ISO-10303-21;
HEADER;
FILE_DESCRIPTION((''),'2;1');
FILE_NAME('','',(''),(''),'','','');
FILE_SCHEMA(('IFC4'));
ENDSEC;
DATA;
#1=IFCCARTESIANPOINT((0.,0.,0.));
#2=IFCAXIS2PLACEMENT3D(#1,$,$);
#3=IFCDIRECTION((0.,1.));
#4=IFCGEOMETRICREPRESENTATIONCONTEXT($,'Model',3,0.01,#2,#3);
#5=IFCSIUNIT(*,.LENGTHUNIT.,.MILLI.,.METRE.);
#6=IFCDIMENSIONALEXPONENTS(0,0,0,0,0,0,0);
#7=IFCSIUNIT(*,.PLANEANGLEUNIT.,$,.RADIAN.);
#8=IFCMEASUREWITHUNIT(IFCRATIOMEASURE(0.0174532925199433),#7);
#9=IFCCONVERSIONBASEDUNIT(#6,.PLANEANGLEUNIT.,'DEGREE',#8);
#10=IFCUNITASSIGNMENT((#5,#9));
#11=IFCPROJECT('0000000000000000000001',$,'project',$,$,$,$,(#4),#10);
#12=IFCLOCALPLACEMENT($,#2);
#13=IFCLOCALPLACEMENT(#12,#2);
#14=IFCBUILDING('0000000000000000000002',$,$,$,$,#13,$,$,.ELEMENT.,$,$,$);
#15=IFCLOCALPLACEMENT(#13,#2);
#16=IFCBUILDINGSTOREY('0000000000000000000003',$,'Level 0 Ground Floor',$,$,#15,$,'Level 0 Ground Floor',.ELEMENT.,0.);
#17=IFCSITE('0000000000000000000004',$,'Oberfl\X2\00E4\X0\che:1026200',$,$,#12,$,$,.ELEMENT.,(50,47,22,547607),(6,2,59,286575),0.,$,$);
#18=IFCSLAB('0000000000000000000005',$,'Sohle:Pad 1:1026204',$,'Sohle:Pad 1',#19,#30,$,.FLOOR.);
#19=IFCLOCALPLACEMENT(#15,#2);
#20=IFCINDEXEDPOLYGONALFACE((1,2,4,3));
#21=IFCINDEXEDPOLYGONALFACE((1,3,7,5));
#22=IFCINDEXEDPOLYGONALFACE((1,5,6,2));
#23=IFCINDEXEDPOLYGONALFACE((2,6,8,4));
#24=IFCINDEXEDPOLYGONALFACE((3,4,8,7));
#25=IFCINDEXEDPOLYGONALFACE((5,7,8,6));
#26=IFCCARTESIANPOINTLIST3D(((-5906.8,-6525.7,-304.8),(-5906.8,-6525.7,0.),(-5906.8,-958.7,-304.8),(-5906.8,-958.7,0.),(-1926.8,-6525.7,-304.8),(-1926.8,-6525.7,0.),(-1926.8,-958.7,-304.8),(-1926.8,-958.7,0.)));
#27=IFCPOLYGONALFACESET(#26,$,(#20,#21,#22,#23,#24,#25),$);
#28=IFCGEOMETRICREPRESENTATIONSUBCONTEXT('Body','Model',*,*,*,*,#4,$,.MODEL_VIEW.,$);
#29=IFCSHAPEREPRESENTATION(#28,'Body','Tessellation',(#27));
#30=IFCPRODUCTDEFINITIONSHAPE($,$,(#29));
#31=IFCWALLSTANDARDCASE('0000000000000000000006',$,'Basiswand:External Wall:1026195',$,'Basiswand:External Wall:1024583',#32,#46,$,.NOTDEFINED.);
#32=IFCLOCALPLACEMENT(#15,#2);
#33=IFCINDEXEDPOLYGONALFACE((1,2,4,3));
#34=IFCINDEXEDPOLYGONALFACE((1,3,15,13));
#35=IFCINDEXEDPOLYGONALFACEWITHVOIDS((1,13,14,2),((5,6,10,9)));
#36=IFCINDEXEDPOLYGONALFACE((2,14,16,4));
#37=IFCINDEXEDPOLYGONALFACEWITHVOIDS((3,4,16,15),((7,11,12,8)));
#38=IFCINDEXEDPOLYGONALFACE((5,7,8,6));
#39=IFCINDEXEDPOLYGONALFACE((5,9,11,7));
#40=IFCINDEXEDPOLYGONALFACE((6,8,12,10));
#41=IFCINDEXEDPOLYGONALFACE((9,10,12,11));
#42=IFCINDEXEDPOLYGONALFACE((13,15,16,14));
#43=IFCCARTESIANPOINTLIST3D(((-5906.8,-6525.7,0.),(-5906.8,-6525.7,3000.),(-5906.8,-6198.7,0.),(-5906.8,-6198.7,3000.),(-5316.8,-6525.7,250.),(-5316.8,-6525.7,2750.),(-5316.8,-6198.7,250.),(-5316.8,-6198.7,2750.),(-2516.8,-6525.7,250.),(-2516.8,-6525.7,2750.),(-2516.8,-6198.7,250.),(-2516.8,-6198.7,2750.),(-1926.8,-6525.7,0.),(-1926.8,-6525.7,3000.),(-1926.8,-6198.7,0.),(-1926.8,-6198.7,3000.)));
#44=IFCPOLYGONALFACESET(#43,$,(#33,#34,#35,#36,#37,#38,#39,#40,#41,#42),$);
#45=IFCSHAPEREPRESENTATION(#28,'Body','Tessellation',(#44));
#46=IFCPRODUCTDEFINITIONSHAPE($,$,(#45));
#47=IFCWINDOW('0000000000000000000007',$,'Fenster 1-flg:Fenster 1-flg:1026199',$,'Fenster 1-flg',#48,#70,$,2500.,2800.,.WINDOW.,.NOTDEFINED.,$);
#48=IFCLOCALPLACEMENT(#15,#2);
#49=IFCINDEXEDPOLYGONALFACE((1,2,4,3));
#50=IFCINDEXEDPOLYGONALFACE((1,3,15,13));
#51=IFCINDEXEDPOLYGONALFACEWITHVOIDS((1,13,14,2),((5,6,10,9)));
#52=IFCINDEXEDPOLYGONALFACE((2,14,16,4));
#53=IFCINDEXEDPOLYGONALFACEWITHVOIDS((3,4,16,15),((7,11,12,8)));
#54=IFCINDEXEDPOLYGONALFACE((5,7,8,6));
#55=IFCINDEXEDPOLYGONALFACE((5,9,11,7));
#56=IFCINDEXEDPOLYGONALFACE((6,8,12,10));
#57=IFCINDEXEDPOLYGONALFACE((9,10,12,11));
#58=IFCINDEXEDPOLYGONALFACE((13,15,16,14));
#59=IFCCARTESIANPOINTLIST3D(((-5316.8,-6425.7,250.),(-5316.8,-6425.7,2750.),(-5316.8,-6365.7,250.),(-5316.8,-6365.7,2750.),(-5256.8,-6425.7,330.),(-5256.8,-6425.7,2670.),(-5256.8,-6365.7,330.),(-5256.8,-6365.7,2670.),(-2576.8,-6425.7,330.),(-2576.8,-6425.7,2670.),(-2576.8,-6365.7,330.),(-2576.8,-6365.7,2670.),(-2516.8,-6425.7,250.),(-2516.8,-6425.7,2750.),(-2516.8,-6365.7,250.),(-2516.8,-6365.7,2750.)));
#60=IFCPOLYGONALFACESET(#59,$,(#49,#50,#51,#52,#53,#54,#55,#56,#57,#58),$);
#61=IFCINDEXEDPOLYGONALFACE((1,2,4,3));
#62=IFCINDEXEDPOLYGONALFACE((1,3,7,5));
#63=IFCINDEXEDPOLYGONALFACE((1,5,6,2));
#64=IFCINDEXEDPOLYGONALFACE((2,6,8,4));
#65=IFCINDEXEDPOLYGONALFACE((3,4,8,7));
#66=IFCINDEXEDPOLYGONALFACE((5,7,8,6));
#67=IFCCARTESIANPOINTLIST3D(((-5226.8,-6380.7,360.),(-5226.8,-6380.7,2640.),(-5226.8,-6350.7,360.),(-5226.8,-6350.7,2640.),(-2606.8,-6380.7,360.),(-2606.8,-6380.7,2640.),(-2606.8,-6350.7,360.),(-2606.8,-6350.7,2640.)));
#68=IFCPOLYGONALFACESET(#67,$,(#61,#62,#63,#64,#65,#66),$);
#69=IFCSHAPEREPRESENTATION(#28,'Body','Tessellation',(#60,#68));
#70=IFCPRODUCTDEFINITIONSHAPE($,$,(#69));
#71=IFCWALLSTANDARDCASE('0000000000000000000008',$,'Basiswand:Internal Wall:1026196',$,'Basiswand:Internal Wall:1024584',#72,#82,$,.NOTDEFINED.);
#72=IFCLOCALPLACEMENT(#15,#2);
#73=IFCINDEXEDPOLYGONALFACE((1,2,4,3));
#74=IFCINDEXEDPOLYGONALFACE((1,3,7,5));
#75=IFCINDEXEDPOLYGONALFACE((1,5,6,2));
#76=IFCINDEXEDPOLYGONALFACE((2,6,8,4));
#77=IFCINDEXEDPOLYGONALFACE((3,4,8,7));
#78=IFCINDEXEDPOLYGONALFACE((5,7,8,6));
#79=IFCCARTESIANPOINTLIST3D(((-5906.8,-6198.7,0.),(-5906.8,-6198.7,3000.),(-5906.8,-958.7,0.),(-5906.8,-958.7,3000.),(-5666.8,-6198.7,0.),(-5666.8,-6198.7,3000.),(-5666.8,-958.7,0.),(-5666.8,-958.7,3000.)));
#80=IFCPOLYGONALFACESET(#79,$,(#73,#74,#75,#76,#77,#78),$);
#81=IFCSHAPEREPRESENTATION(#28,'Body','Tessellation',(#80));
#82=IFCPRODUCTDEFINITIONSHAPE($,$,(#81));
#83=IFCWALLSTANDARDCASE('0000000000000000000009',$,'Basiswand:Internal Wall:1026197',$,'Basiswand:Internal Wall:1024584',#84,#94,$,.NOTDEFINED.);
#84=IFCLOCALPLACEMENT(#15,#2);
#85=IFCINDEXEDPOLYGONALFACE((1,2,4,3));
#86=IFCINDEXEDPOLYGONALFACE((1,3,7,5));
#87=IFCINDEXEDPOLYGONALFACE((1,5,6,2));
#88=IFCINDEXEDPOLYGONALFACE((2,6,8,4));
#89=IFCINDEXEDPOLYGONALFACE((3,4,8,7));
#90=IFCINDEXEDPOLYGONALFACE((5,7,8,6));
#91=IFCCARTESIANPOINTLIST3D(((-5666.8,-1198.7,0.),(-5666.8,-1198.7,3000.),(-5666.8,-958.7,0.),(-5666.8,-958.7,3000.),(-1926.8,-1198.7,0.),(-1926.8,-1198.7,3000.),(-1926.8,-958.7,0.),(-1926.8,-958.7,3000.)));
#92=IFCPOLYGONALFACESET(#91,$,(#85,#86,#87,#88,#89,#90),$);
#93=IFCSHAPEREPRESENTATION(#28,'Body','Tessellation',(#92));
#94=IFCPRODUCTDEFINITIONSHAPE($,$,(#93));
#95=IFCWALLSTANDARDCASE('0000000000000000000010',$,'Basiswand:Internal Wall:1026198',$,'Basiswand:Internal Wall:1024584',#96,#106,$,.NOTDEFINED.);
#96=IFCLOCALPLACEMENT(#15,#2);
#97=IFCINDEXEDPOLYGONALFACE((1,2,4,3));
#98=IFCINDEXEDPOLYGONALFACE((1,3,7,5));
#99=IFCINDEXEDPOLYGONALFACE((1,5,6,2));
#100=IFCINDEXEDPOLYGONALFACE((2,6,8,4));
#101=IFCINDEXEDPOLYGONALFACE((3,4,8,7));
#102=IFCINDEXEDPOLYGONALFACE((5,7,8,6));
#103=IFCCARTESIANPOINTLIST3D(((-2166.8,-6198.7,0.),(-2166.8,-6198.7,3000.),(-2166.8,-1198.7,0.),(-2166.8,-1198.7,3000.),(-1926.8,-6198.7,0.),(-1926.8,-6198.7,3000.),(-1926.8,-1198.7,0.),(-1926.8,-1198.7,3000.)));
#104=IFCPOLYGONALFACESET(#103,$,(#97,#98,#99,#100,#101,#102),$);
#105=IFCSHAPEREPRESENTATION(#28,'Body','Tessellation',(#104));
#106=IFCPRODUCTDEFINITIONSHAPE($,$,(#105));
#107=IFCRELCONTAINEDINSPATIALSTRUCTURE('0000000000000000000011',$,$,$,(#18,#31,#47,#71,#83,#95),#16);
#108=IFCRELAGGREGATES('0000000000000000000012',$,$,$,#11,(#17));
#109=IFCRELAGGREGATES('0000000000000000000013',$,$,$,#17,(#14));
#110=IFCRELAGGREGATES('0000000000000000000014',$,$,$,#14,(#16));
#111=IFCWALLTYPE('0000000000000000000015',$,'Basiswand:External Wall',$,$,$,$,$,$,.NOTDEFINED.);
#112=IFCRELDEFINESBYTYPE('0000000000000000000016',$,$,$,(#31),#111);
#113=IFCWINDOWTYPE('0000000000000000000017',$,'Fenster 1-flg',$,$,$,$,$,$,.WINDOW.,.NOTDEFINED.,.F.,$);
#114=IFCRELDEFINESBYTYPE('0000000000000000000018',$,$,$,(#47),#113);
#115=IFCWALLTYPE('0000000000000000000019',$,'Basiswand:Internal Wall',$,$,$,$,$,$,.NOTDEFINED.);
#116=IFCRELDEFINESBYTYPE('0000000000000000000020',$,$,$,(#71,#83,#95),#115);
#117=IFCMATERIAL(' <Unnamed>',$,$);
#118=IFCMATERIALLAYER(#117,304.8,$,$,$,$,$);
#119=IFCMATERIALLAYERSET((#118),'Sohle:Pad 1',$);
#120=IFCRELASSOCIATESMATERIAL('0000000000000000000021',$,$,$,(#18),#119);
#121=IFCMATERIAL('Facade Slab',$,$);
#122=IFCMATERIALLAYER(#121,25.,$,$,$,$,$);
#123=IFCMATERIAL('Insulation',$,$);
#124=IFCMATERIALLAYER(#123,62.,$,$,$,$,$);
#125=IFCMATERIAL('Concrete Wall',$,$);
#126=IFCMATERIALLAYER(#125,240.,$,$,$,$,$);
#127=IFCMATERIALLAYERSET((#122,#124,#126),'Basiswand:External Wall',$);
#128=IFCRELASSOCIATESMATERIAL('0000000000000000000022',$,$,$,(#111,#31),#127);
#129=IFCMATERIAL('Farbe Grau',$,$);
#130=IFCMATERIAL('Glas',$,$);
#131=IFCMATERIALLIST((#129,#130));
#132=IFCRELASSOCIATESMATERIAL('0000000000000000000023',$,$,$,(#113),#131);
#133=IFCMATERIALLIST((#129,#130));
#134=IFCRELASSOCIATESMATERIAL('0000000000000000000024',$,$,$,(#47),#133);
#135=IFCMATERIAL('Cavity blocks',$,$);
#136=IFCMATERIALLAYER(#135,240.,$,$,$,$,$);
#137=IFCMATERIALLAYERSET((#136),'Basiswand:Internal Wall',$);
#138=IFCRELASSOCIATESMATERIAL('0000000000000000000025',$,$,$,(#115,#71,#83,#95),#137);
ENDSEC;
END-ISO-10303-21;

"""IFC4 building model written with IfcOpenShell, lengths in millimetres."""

from ifc_helpers import new_model, entity, si_unit, converted_unit, direction, frame, frame_2d, origin, origin_2d_with_axis, place, context, subcontext, project, spatial, polyline, rectangle, outline, extrude, clip, bounded_halfspace, source, transform, mapped, material, material_list, layer, layer_set, layer_usage, type_object, type_shapes, element, fill, save


model = new_model("IFC4")

# Units and contexts
model_context = context("Model", 3, precision=0.01, world=origin(), true_north=direction((0.0, 1.0)))
body_context = subcontext(model_context, "Body", "Model", "MODEL_VIEW")
ifc_project = project(units=[si_unit("LENGTHUNIT", "METRE", prefix="MILLI"), converted_unit("PLANEANGLEUNIT", "DEGREE", entity("IfcRatioMeasure", 0.0174532925199433), si_unit("PLANEANGLEUNIT", "RADIAN"), dimensions=[0, 0, 0, 0, 0, 0, 0])], contexts=[model_context])

# Site, building, storey
site_placement = place(None, origin())
site = spatial("IfcSite", under=ifc_project, at=site_placement, Name="Oberfläche:1026200", CompositionType="ELEMENT", RefLatitude=(50, 47, 22, 547607), RefLongitude=(6, 2, 59, 286575), RefElevation=0.0)
building_placement = place(site_placement, origin())
building = spatial("IfcBuilding", under=site, at=building_placement, CompositionType="ELEMENT")
storey_placement = place(building_placement, origin())
storey = spatial("IfcBuildingStorey", under=building, at=storey_placement, Name="Level 0 Ground Floor", LongName="Level 0 Ground Floor", CompositionType="ELEMENT", Elevation=0.0)

# Slab
ifc_material_1 = material(Name=" <Unnamed>")
ifc_layer_1 = layer(ifc_material_1, 304.8)
ifc_layer_set_1 = layer_set([ifc_layer_1], Name="Sohle:Pad 1")
ifc_layer_usage_1 = layer_usage(ifc_layer_set_1, "AXIS3", "NEGATIVE", 0.0)
slab_placement = place(storey_placement, origin())
element("IfcSlab", 1, at=slab_placement, inside=storey, material=ifc_layer_usage_1, Name="Sohle:Pad 1:1026204", ObjectType="Sohle:Pad 1", PredefinedType="FLOOR", context=body_context, shape_type="SweptSolid", body=[
    extrude(rectangle(XDim=3980.0, YDim=5567.0, at=frame_2d((0.0, 0.0), x_axis=(1.0, 0.0))), frame((-3916.8, -3742.2, -304.8), z_axis=(0.0, 0.0, 1.0), x_axis=(-1.0, 0.0, 0.0)), (0.0, 0.0, 1.0), 304.8),
])

# Wall, opening, window
ifc_material_2 = material(Name="Facade Slab")
ifc_layer_2 = layer(ifc_material_2, 25.0)
ifc_material_3 = material(Name="Insulation")
ifc_layer_3 = layer(ifc_material_3, 62.0)
ifc_material_4 = material(Name="Concrete Wall")
ifc_layer_4 = layer(ifc_material_4, 240.0)
ifc_layer_set_2 = layer_set([ifc_layer_2, ifc_layer_3, ifc_layer_4], Name="Basiswand:External Wall")
ifc_layer_usage_2 = layer_usage(ifc_layer_set_2, "AXIS2", "POSITIVE", -163.5)
wall_type_1 = type_object("IfcWallType", Name="Basiswand:External Wall", PredefinedType="NOTDEFINED", material=ifc_layer_set_2)
wall_1_placement = place(storey_placement, frame((-5906.8, -6362.2, 0.0)))
wall_1 = element("IfcWallStandardCase", 2, at=wall_1_placement, inside=storey, type_object=wall_type_1, material=ifc_layer_usage_2, Name="Basiswand:External Wall:1026195", ObjectType="Basiswand:External Wall:1024583", PredefinedType="NOTDEFINED", context=body_context, shape_type="Clipping", body=[
    clip(extrude(rectangle(XDim=3980.0, YDim=327.0, at=frame_2d((1990.0, 0.0), x_axis=(-1.0, 0.0))), origin(), (0.0, 0.0, 1.0), 3000.0), bounded_halfspace(frame((0.0, -163.5, 3000.0), z_axis=(0.0, 0.0, -1.0), x_axis=(0.0, -1.0, 0.0)), True, frame((0.0, -163.5, 3000.0)), polyline([(0.0, 0.0), (3980.0, 0.0), (3980.0, 327.0), (3740.0, 327.0), (240.0, 327.0), (0.0, 327.0), (0.0, 0.0)]))),
])
opening_placement = place(wall_1_placement, frame((590.0, -163.5, 250.0)))
opening = element("IfcOpeningElement", 3, at=opening_placement, cuts=wall_1, ObjectType="Opening", PredefinedType="OPENING", context=body_context, shape_type="SweptSolid", body=[
    extrude(rectangle(XDim=2500.0, YDim=2800.0, at=frame_2d((1250.0, 1400.0), x_axis=(1.0, 0.0))), frame((0.0, 0.0, 0.0), z_axis=(0.0, 1.0, 0.0), x_axis=(0.0, 0.0, 1.0)), (0.0, 0.0, 1.0), 327.0),
])
ifc_material_5 = material(Name="Farbe Grau")
ifc_material_6 = material(Name="Glas")
ifc_material_list_1 = material_list([ifc_material_5, ifc_material_6])
ifc_material_list_2 = material_list([ifc_material_5, ifc_material_6])
window_type = type_object("IfcWindowType", Name="Fenster 1-flg", ParameterTakesPrecedence=False, PartitioningType="NOTDEFINED", PredefinedType="WINDOW", material=ifc_material_list_2)
shared_shape_1 = source(origin(), body_context, "Body", "SweptSolid", [
    extrude(outline(polyline([(-1250.0, -1400.0), (1250.0, -1400.0), (1250.0, 1400.0), (-1250.0, 1400.0), (-1250.0, -1400.0)]), holes=[polyline([(-1170.0, -1340.0), (-1170.0, 1340.0), (1170.0, 1340.0), (1170.0, -1340.0), (-1170.0, -1340.0)])]), frame((1400.0, 167.0, 1250.0), z_axis=(0.0, 1.0, 0.0), x_axis=(0.0, 0.0, -1.0)), (0.0, 0.0, 1.0), 60.0),
    extrude(rectangle(XDim=30.0, YDim=2620.0, at=origin_2d_with_axis()), frame((1400.0, 167.0, 110.0), z_axis=(0.0, 0.0, 1.0), x_axis=(0.0, 1.0, 0.0)), (0.0, 0.0, 1.0), 2280.0),
])
type_shapes(window_type, [shared_shape_1])
window_placement = place(opening_placement, frame((2800.0, 327.0, 0.0), z_axis=(0.0, 0.0, 1.0), x_axis=(-1.0, 0.0, 0.0)))
window = element("IfcWindow", 4, at=window_placement, inside=storey, type_object=window_type, material=ifc_material_list_1, Name="Fenster 1-flg:Fenster 1-flg:1026199", ObjectType="Fenster 1-flg", OverallHeight=2500.0, OverallWidth=2800.0, PartitioningType="NOTDEFINED", PredefinedType="WINDOW", context=body_context, shape_type="MappedRepresentation", body=[
    mapped(shared_shape_1, transform((0.0, 0.0, 0.0), scale=1.0)),
])
fill(opening, window)

# Walls
ifc_material_7 = material(Name="Cavity blocks")
ifc_layer_5 = layer(ifc_material_7, 240.0)
ifc_layer_set_3 = layer_set([ifc_layer_5], Name="Basiswand:Internal Wall")
ifc_layer_usage_3 = layer_usage(ifc_layer_set_3, "AXIS2", "NEGATIVE", 120.0)
wall_type_2 = type_object("IfcWallType", Name="Basiswand:Internal Wall", PredefinedType="NOTDEFINED", material=ifc_layer_set_3)
wall_2_placement = place(storey_placement, frame((-5786.8, -6198.7, 0.0), z_axis=(0.0, 0.0, 1.0), x_axis=(0.0, 1.0, 0.0)))
element("IfcWallStandardCase", 5, at=wall_2_placement, inside=storey, type_object=wall_type_2, material=ifc_layer_usage_3, Name="Basiswand:Internal Wall:1026196", ObjectType="Basiswand:Internal Wall:1024584", PredefinedType="NOTDEFINED", context=body_context, shape_type="Clipping", body=[
    clip(extrude(rectangle(XDim=5240.0, YDim=240.0, at=frame_2d((2620.0, 0.0), x_axis=(-1.0, 0.0))), origin(), (0.0, 0.0, 1.0), 3000.0), bounded_halfspace(frame((0.0, -120.0, 3000.0), z_axis=(0.0, 0.0, -1.0), x_axis=(-1.0, 0.0, 0.0)), True, frame((0.0, -120.0, 3000.0)), polyline([(0.0, 0.0), (5000.0, 0.0), (5240.0, 0.0), (5240.0, 240.0), (0.0, 240.0), (0.0, 0.0)]))),
])
ifc_layer_usage_4 = layer_usage(ifc_layer_set_3, "AXIS2", "NEGATIVE", 120.0)
wall_3_placement = place(storey_placement, frame((-5666.8, -1078.7, 0.0)))
element("IfcWallStandardCase", 6, at=wall_3_placement, inside=storey, type_object=wall_type_2, material=ifc_layer_usage_4, Name="Basiswand:Internal Wall:1026197", ObjectType="Basiswand:Internal Wall:1024584", PredefinedType="NOTDEFINED", context=body_context, shape_type="Clipping", body=[
    clip(extrude(rectangle(XDim=3740.0, YDim=240.0, at=frame_2d((1870.0, 0.0), x_axis=(-1.0, 0.0))), origin(), (0.0, 0.0, 1.0), 3000.0), bounded_halfspace(frame((0.0, -120.0, 3000.0), z_axis=(0.0, 0.0, -1.0), x_axis=(0.0, -1.0, 0.0)), True, frame((0.0, -120.0, 3000.0)), polyline([(0.0, 0.0), (3500.0, 0.0), (3740.0, 0.0), (3740.0, 240.0), (0.0, 240.0), (0.0, 0.0)]))),
])
ifc_layer_usage_5 = layer_usage(ifc_layer_set_3, "AXIS2", "NEGATIVE", 120.0)
wall_4_placement = place(storey_placement, frame((-2046.8, -1198.7, 0.0), z_axis=(0.0, 0.0, 1.0), x_axis=(0.0, -1.0, 0.0)))
element("IfcWallStandardCase", 7, at=wall_4_placement, inside=storey, type_object=wall_type_2, material=ifc_layer_usage_5, Name="Basiswand:Internal Wall:1026198", ObjectType="Basiswand:Internal Wall:1024584", PredefinedType="NOTDEFINED", context=body_context, shape_type="Clipping", body=[
    clip(extrude(rectangle(XDim=5000.0, YDim=240.0, at=frame_2d((2500.0, 0.0), x_axis=(-1.0, 0.0))), origin(), (0.0, 0.0, 1.0), 3000.0), bounded_halfspace(frame((0.0, -120.0, 3000.0), z_axis=(0.0, 0.0, -1.0), x_axis=(1.0, 0.0, 0.0)), True, frame((0.0, -120.0, 3000.0)), polyline([(0.0, 0.0), (5000.0, 0.0), (5000.0, 240.0), (0.0, 240.0), (0.0, 0.0)]))),
])

save(model, "model.ifc")
